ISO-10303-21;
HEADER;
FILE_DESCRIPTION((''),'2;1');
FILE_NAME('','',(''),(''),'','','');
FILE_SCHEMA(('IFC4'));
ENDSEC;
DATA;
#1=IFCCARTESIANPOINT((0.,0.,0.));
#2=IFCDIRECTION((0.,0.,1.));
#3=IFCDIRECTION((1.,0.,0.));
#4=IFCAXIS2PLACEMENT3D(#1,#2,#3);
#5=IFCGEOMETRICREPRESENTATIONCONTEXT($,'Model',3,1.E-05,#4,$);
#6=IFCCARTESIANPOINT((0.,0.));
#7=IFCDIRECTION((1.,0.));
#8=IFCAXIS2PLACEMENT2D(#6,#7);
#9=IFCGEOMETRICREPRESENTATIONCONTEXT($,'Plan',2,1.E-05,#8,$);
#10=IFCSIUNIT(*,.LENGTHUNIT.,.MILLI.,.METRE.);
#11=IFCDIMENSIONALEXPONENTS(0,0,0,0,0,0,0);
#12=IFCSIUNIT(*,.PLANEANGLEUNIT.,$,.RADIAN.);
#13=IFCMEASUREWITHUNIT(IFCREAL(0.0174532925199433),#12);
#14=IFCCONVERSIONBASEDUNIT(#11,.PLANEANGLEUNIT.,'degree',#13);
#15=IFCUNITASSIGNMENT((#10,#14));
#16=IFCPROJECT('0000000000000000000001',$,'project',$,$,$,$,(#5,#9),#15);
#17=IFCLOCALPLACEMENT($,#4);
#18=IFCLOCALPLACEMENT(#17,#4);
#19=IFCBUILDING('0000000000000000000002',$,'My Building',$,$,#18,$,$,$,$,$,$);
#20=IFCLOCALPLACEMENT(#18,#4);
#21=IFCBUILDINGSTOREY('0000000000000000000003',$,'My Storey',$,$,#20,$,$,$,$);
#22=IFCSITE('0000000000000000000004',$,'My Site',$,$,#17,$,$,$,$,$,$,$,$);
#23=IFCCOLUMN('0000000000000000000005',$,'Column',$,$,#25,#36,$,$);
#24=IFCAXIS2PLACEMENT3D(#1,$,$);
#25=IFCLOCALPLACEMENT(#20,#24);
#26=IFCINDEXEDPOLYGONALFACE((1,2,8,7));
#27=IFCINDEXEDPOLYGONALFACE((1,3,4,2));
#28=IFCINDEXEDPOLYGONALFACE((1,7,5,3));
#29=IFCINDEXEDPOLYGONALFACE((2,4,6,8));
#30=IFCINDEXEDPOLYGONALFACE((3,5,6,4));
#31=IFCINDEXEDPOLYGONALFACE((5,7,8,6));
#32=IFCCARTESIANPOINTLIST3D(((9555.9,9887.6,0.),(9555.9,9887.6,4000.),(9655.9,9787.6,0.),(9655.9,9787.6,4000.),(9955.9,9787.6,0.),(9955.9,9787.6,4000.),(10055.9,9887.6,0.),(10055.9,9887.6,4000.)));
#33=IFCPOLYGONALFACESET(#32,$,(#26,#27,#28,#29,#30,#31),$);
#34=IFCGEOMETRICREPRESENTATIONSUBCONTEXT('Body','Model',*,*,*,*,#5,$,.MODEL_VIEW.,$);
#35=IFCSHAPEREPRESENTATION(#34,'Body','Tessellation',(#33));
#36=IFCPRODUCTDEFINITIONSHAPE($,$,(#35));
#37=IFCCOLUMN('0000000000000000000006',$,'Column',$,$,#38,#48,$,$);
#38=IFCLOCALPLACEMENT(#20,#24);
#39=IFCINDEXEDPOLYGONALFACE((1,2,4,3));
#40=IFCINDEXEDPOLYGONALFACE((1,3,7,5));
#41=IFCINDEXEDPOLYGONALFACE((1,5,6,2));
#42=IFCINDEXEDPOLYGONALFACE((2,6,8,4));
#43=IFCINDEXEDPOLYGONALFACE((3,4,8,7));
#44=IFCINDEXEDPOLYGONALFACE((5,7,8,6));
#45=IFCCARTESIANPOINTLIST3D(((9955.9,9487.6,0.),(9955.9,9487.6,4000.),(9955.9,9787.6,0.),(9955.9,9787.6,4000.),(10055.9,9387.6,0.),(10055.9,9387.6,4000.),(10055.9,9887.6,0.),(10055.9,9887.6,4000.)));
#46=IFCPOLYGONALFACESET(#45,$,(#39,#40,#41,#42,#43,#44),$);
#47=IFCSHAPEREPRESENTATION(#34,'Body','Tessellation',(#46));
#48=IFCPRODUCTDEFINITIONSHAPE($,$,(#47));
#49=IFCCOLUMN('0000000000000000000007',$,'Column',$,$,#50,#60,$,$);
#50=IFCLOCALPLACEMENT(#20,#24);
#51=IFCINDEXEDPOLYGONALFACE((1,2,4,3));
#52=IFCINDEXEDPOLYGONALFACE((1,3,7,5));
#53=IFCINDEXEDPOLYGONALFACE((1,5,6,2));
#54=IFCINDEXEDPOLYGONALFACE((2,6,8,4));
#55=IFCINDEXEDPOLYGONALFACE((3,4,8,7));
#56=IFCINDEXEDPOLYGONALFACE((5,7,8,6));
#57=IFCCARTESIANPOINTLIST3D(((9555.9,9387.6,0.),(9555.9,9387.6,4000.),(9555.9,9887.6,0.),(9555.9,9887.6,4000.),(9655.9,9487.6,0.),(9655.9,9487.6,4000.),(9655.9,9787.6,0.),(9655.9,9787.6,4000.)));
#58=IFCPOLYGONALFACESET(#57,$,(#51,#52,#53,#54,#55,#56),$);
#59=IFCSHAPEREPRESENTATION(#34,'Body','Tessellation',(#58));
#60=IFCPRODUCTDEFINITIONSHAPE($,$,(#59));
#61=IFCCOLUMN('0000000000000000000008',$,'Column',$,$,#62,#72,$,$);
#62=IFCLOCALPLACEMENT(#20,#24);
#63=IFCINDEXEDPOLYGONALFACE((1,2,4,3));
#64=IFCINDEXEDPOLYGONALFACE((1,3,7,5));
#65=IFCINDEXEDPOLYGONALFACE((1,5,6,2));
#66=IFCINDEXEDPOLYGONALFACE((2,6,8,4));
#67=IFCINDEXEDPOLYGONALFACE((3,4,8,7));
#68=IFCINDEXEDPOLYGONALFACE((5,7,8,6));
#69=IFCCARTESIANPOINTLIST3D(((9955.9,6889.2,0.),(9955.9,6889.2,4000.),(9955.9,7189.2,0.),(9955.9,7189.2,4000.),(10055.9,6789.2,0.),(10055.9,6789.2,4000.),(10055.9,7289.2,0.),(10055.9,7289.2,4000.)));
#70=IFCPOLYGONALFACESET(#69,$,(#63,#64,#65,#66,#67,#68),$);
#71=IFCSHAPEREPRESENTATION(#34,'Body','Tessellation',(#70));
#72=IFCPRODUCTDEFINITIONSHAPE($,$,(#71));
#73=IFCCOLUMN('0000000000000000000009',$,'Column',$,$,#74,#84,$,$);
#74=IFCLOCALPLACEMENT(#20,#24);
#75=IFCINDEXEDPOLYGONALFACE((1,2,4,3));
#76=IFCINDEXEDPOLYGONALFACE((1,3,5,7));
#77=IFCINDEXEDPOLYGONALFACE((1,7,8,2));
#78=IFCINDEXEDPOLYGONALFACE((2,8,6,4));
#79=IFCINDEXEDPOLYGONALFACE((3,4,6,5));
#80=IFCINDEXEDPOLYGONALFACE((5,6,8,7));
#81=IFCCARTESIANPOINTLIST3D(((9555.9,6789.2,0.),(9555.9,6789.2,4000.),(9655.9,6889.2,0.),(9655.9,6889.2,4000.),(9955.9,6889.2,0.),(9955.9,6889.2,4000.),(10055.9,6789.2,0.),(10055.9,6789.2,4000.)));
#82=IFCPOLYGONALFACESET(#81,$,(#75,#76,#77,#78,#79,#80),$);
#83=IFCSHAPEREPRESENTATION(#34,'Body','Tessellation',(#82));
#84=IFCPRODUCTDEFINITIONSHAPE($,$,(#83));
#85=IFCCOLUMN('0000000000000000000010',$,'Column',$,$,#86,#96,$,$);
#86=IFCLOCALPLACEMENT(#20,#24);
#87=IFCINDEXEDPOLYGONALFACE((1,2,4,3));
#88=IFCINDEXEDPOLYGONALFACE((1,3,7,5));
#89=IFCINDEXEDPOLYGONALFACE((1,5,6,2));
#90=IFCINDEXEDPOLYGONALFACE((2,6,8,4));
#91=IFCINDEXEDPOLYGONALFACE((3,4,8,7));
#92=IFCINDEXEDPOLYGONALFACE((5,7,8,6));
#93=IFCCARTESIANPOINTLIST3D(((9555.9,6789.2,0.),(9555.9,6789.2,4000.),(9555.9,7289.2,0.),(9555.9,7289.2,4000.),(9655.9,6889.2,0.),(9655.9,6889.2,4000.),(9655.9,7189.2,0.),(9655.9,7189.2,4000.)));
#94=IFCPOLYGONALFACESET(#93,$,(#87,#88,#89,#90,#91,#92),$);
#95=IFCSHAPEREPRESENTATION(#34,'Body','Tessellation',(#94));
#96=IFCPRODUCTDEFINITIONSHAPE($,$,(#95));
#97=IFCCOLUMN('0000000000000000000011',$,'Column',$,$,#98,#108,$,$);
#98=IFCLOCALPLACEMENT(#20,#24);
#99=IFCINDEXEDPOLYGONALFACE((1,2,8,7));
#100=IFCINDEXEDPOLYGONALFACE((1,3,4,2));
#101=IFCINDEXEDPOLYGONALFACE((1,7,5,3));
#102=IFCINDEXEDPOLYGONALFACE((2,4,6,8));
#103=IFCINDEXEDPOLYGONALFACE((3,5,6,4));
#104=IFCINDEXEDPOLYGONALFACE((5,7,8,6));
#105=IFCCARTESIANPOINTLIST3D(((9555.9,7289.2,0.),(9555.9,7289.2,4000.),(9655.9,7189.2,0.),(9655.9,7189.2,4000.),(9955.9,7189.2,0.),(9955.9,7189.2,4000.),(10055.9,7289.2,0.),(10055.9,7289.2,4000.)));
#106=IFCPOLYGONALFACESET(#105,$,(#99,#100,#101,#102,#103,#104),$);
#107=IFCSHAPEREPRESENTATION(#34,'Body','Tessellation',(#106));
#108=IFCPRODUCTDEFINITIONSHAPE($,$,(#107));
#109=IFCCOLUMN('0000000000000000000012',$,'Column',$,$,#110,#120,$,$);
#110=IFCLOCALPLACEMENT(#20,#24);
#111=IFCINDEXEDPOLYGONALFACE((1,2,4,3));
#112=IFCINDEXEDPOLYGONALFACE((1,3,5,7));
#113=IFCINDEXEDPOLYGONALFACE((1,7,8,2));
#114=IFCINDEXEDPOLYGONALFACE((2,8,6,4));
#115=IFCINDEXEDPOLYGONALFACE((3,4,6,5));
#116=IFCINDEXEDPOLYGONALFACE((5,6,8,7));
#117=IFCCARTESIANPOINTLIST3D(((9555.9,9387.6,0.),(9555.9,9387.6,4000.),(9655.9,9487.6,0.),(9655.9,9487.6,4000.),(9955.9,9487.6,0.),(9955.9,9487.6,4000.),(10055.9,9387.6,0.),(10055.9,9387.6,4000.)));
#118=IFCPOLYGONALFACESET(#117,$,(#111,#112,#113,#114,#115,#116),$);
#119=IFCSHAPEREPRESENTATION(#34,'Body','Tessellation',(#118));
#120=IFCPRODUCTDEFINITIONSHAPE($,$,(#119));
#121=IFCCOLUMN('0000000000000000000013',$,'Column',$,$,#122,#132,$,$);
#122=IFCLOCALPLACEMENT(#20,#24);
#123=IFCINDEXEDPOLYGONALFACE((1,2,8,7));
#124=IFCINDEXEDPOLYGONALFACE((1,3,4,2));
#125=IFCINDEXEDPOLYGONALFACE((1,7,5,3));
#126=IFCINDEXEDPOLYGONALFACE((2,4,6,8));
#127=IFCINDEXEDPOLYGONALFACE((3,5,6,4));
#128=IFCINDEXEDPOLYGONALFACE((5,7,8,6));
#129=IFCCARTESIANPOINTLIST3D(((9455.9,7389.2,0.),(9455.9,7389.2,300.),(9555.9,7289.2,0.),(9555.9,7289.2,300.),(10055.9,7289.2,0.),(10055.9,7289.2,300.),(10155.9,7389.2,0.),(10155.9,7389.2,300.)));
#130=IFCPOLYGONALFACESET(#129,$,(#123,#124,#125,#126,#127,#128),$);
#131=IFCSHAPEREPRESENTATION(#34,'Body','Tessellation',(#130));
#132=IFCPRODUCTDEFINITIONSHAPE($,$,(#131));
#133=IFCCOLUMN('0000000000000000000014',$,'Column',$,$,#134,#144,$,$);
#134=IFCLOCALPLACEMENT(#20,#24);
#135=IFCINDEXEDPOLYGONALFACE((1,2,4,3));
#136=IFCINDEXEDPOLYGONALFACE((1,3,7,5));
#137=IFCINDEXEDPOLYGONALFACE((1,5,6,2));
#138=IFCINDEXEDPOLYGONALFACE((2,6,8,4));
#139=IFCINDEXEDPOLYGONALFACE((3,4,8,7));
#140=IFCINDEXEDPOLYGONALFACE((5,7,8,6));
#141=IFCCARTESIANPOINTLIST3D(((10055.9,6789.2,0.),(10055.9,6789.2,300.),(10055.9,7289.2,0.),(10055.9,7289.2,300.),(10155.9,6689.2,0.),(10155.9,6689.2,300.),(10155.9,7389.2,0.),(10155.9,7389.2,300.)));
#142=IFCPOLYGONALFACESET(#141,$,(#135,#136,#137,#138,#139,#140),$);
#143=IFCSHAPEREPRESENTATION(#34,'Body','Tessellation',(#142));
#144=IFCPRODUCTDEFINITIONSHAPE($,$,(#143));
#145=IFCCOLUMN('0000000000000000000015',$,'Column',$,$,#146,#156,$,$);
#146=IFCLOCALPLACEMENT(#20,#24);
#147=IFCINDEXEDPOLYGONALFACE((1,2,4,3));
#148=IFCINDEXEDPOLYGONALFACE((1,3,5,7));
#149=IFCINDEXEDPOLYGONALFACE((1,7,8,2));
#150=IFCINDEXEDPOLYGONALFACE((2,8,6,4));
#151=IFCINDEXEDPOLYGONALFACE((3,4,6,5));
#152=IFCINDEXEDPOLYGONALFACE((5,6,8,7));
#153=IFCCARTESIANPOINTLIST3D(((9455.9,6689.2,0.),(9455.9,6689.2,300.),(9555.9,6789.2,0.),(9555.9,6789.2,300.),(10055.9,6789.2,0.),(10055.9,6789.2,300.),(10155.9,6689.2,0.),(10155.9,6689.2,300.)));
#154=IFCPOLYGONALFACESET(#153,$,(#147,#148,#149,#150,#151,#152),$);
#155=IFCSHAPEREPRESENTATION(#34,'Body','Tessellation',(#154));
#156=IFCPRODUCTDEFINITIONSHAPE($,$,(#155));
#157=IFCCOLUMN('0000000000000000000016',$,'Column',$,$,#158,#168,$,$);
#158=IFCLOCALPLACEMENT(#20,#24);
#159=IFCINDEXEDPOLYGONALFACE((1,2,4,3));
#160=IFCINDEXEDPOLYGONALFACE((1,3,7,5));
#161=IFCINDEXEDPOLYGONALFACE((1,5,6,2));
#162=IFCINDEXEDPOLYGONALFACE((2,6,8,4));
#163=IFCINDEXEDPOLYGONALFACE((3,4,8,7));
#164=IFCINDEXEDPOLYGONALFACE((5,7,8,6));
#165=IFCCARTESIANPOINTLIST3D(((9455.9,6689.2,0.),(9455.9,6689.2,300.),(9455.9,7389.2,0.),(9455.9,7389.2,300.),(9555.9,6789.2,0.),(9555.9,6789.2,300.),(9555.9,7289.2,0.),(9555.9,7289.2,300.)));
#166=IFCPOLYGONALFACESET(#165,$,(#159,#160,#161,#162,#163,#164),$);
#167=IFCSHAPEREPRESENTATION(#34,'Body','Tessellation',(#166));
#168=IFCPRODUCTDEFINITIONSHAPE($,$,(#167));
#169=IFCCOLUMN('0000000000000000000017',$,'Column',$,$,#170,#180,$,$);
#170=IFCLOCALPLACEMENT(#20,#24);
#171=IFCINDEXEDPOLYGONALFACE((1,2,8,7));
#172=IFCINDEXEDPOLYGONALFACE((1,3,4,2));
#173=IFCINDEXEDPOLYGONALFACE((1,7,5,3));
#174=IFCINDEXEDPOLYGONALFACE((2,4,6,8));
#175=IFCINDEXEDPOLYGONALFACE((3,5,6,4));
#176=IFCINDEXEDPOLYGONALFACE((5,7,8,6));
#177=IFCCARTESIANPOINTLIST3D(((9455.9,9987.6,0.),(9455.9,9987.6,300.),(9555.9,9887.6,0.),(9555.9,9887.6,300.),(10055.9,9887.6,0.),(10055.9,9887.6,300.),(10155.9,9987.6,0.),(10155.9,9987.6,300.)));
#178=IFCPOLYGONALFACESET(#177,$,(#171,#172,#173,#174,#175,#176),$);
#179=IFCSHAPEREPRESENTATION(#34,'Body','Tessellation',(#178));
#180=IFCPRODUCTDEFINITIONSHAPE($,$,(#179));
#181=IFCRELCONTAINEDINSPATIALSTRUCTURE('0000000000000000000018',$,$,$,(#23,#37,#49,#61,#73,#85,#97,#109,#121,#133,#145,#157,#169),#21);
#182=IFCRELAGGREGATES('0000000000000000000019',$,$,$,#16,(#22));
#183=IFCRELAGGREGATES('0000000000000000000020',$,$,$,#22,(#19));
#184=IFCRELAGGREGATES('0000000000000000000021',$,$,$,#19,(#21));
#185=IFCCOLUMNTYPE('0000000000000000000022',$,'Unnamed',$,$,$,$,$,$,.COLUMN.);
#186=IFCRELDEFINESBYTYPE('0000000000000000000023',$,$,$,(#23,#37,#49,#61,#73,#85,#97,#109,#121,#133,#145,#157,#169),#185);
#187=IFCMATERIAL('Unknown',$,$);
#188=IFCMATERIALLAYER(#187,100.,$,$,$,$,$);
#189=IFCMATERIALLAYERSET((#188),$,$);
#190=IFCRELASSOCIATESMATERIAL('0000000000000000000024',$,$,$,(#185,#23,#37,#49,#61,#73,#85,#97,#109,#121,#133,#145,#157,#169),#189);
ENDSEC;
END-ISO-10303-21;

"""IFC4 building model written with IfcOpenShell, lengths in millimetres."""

from ifc_helpers import new_model, entity, si_unit, converted_unit, frame, origin_with_axes, origin_2d_with_axis, place, context, subcontext, project, spatial, line, indexed_curve, outline, extrude, material, layer, layer_set, layer_usage, type_object, element, save


model = new_model("IFC4")

# Units and contexts
model_context = context("Model", 3, precision=1e-05, world=origin_with_axes())
plan_context = context("Plan", 2, precision=1e-05, world=origin_2d_with_axis())
body_context = subcontext(model_context, "Body", "Model", "MODEL_VIEW")
ifc_project = project(units=[si_unit("LENGTHUNIT", "METRE", prefix="MILLI"), converted_unit("PLANEANGLEUNIT", "degree", entity("IfcReal", 0.0174532925199433), si_unit("PLANEANGLEUNIT", "RADIAN"), dimensions=[0, 0, 0, 0, 0, 0, 0])], contexts=[model_context, plan_context])

# Site, building, storey
site_placement = place(None, origin_with_axes())
site = spatial("IfcSite", under=ifc_project, at=site_placement, Name="My Site")
building_placement = place(site_placement, origin_with_axes())
building = spatial("IfcBuilding", under=site, at=building_placement, Name="My Building")
storey_placement = place(building_placement, origin_with_axes())
storey = spatial("IfcBuildingStorey", under=building, at=storey_placement, Name="My Storey")

# Columns
ifc_material = material(Name="Unknown")
ifc_layer_1 = layer(ifc_material, 100.0)
ifc_layer_set_1 = layer_set([ifc_layer_1])
ifc_layer_usage_1 = layer_usage(ifc_layer_set_1, "AXIS2", "POSITIVE", 0.0)
column_type = type_object("IfcColumnType", Name="Unnamed", PredefinedType="COLUMN", material=ifc_layer_set_1)
column_1_placement = place(storey_placement, frame((9655.9, 9787.6, 0.0), z_axis=(0.0, 0.0, 1.0), x_axis=(1.0, 0.0, 0.0)))
element("IfcColumn", 1, at=column_1_placement, inside=storey, type_object=column_type, material=ifc_layer_usage_1, Name="Column", context=body_context, shape_type="SweptSolid", body=[
    extrude(outline(indexed_curve([(0.0, 0.0), (-100.0, 100.0), (400.0, 100.0), (300.0, 0.0)], segments=[line(1, 2, 3, 4, 1)])), origin_with_axes(), (0.0, 0.0, 1.0), 4000.0),
])
ifc_layer_usage_2 = layer_usage(ifc_layer_set_1, "AXIS2", "POSITIVE", 0.0)
column_2_placement = place(storey_placement, frame((9955.9, 9787.6, 0.0), z_axis=(0.0, 0.0, 1.0), x_axis=(0.0, -1.0, 0.0)))
element("IfcColumn", 2, at=column_2_placement, inside=storey, type_object=column_type, material=ifc_layer_usage_2, Name="Column", context=body_context, shape_type="SweptSolid", body=[
    extrude(outline(indexed_curve([(0.0, 0.0), (-100.0, 100.0), (400.0, 100.0), (300.0, 0.0)], segments=[line(1, 2, 3, 4, 1)])), origin_with_axes(), (0.0, 0.0, 1.0), 4000.0),
])
ifc_layer_usage_3 = layer_usage(ifc_layer_set_1, "AXIS2", "POSITIVE", 0.0)
column_3_placement = place(storey_placement, frame((9655.9, 9487.6, 0.0), z_axis=(0.0, 0.0, 1.0), x_axis=(0.0, 1.0, 0.0)))
element("IfcColumn", 3, at=column_3_placement, inside=storey, type_object=column_type, material=ifc_layer_usage_3, Name="Column", context=body_context, shape_type="SweptSolid", body=[
    extrude(outline(indexed_curve([(0.0, 0.0), (-100.0, 100.0), (400.0, 100.0), (300.0, 0.0)], segments=[line(1, 2, 3, 4, 1)])), origin_with_axes(), (0.0, 0.0, 1.0), 4000.0),
])
ifc_layer_usage_4 = layer_usage(ifc_layer_set_1, "AXIS2", "POSITIVE", 0.0)
column_4_placement = place(storey_placement, frame((9955.9, 7189.2, 0.0), z_axis=(0.0, 0.0, 1.0), x_axis=(0.0, -1.0, 0.0)))
element("IfcColumn", 4, at=column_4_placement, inside=storey, type_object=column_type, material=ifc_layer_usage_4, Name="Column", context=body_context, shape_type="SweptSolid", body=[
    extrude(outline(indexed_curve([(0.0, 0.0), (-100.0, 100.0), (400.0, 100.0), (300.0, 0.0)], segments=[line(1, 2, 3, 4, 1)])), origin_with_axes(), (0.0, 0.0, 1.0), 4000.0),
])
ifc_layer_usage_5 = layer_usage(ifc_layer_set_1, "AXIS2", "POSITIVE", 0.0)
column_5_placement = place(storey_placement, frame((9955.9, 6889.2, 0.0), z_axis=(0.0, 0.0, 1.0), x_axis=(-1.0, 0.0, 0.0)))
element("IfcColumn", 5, at=column_5_placement, inside=storey, type_object=column_type, material=ifc_layer_usage_5, Name="Column", context=body_context, shape_type="SweptSolid", body=[
    extrude(outline(indexed_curve([(0.0, 0.0), (-100.0, 100.0), (400.0, 100.0), (300.0, 0.0)], segments=[line(1, 2, 3, 4, 1)])), origin_with_axes(), (0.0, 0.0, 1.0), 4000.0),
])
ifc_layer_usage_6 = layer_usage(ifc_layer_set_1, "AXIS2", "POSITIVE", 0.0)
column_6_placement = place(storey_placement, frame((9655.9, 6889.2, 0.0), z_axis=(0.0, 0.0, 1.0), x_axis=(0.0, 1.0, 0.0)))
element("IfcColumn", 6, at=column_6_placement, inside=storey, type_object=column_type, material=ifc_layer_usage_6, Name="Column", context=body_context, shape_type="SweptSolid", body=[
    extrude(outline(indexed_curve([(0.0, 0.0), (-100.0, 100.0), (400.0, 100.0), (300.0, 0.0)], segments=[line(1, 2, 3, 4, 1)])), origin_with_axes(), (0.0, 0.0, 1.0), 4000.0),
])
ifc_layer_usage_7 = layer_usage(ifc_layer_set_1, "AXIS2", "POSITIVE", 0.0)
column_7_placement = place(storey_placement, frame((9655.9, 7189.2, 0.0), z_axis=(0.0, 0.0, 1.0), x_axis=(1.0, 0.0, 0.0)))
element("IfcColumn", 7, at=column_7_placement, inside=storey, type_object=column_type, material=ifc_layer_usage_7, Name="Column", context=body_context, shape_type="SweptSolid", body=[
    extrude(outline(indexed_curve([(0.0, 0.0), (-100.0, 100.0), (400.0, 100.0), (300.0, 0.0)], segments=[line(1, 2, 3, 4, 1)])), origin_with_axes(), (0.0, 0.0, 1.0), 4000.0),
])
ifc_layer_usage_8 = layer_usage(ifc_layer_set_1, "AXIS2", "POSITIVE", 0.0)
column_8_placement = place(storey_placement, frame((9955.9, 9487.6, 0.0), z_axis=(0.0, 0.0, 1.0), x_axis=(-1.0, 0.0, 0.0)))
element("IfcColumn", 8, at=column_8_placement, inside=storey, type_object=column_type, material=ifc_layer_usage_8, Name="Column", context=body_context, shape_type="SweptSolid", body=[
    extrude(outline(indexed_curve([(0.0, 0.0), (-100.0, 100.0), (400.0, 100.0), (300.0, 0.0)], segments=[line(1, 2, 3, 4, 1)])), origin_with_axes(), (0.0, 0.0, 1.0), 4000.0),
])
ifc_layer_usage_9 = layer_usage(ifc_layer_set_1, "AXIS2", "POSITIVE", 0.0)
column_9_placement = place(storey_placement, frame((9555.9, 7289.2, 0.0), z_axis=(0.0, 0.0, 1.0), x_axis=(1.0, 0.0, 0.0)))
element("IfcColumn", 9, at=column_9_placement, inside=storey, type_object=column_type, material=ifc_layer_usage_9, Name="Column", context=body_context, shape_type="SweptSolid", body=[
    extrude(outline(indexed_curve([(0.0, 0.0), (-100.0, 100.0), (600.0, 100.0), (500.0, 0.0)], segments=[line(1, 2, 3, 4, 1)])), origin_with_axes(), (0.0, 0.0, 1.0), 300.0),
])
ifc_layer_usage_10 = layer_usage(ifc_layer_set_1, "AXIS2", "POSITIVE", 0.0)
column_10_placement = place(storey_placement, frame((10055.9, 7289.2, 0.0), z_axis=(0.0, 0.0, 1.0), x_axis=(0.0, -1.0, 0.0)))
element("IfcColumn", 10, at=column_10_placement, inside=storey, type_object=column_type, material=ifc_layer_usage_10, Name="Column", context=body_context, shape_type="SweptSolid", body=[
    extrude(outline(indexed_curve([(0.0, 0.0), (-100.0, 100.0), (600.0, 100.0), (500.0, 0.0)], segments=[line(1, 2, 3, 4, 1)])), origin_with_axes(), (0.0, 0.0, 1.0), 300.0),
])
ifc_layer_usage_11 = layer_usage(ifc_layer_set_1, "AXIS2", "POSITIVE", 0.0)
column_11_placement = place(storey_placement, frame((10055.9, 6789.2, 0.0), z_axis=(0.0, 0.0, 1.0), x_axis=(-1.0, 0.0, 0.0)))
element("IfcColumn", 11, at=column_11_placement, inside=storey, type_object=column_type, material=ifc_layer_usage_11, Name="Column", context=body_context, shape_type="SweptSolid", body=[
    extrude(outline(indexed_curve([(0.0, 0.0), (-100.0, 100.0), (600.0, 100.0), (500.0, 0.0)], segments=[line(1, 2, 3, 4, 1)])), origin_with_axes(), (0.0, 0.0, 1.0), 300.0),
])
ifc_layer_usage_12 = layer_usage(ifc_layer_set_1, "AXIS2", "POSITIVE", 0.0)
column_12_placement = place(storey_placement, frame((9555.9, 6789.2, 0.0), z_axis=(0.0, 0.0, 1.0), x_axis=(-0.000002, 1.0, 0.0)))
element("IfcColumn", 12, at=column_12_placement, inside=storey, type_object=column_type, material=ifc_layer_usage_12, Name="Column", context=body_context, shape_type="SweptSolid", body=[
    extrude(outline(indexed_curve([(0.0, 0.0), (-100.0, 100.0), (600.0, 100.0), (500.0, 0.0)], segments=[line(1, 2, 3, 4, 1)])), origin_with_axes(), (0.0, 0.0, 1.0), 300.0),
])
ifc_layer_usage_13 = layer_usage(ifc_layer_set_1, "AXIS2", "POSITIVE", 0.0)
column_13_placement = place(storey_placement, frame((9555.9, 9887.6, 0.0), z_axis=(0.0, 0.0, 1.0), x_axis=(1.0, 0.0, 0.0)))
element("IfcColumn", 13, at=column_13_placement, inside=storey, type_object=column_type, material=ifc_layer_usage_13, Name="Column", context=body_context, shape_type="SweptSolid", body=[
    extrude(outline(indexed_curve([(0.0, 0.0), (-100.0, 100.0), (600.0, 100.0), (500.0, 0.0)], segments=[line(1, 2, 3, 4, 1)])), origin_with_axes(), (0.0, 0.0, 1.0), 300.0),
])

save(model, "model.ifc")
